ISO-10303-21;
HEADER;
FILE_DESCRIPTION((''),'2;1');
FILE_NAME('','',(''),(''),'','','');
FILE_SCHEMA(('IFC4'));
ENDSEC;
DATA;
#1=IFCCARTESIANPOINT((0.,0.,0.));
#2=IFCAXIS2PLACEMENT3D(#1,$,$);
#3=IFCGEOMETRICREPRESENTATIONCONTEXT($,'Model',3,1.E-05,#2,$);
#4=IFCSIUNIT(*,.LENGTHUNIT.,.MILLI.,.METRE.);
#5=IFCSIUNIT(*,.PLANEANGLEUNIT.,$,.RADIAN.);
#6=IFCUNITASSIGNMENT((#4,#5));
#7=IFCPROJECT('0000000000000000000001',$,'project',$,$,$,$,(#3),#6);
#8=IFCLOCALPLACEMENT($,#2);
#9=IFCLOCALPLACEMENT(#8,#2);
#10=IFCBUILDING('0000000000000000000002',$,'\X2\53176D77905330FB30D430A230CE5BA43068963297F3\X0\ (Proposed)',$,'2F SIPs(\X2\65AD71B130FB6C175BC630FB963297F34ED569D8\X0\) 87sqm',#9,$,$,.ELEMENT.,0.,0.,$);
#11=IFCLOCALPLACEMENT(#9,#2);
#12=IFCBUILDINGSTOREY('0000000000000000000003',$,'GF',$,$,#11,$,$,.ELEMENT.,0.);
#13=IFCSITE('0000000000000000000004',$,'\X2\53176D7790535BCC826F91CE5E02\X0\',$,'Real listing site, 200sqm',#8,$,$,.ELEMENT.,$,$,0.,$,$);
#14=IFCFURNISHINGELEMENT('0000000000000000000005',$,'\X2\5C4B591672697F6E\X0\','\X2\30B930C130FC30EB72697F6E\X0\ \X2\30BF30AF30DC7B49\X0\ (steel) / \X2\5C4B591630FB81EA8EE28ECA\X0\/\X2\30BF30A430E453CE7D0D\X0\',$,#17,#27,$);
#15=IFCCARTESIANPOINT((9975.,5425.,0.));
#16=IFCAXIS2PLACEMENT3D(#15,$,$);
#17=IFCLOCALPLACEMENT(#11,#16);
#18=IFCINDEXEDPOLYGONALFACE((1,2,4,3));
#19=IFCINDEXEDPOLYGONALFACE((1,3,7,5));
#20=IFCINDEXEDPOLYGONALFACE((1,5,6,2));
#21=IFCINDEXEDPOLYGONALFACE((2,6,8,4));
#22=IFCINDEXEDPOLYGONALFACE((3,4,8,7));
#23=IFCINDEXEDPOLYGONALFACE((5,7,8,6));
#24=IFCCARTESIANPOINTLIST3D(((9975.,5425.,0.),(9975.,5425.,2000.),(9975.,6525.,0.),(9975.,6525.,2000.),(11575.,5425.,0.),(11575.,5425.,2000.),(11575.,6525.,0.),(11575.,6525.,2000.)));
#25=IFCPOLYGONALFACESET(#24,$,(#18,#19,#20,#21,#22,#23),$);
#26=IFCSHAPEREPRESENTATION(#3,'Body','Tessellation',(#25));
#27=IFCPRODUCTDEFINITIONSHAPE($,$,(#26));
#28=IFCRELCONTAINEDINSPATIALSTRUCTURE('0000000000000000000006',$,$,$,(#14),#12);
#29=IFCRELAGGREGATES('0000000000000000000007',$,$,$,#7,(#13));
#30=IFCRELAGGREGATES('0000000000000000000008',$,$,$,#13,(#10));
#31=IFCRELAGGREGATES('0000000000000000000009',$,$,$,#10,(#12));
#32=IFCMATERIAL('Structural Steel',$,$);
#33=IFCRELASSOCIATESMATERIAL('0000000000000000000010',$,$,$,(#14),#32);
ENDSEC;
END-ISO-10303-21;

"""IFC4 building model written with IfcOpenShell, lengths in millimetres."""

from ifc_helpers import new_model, si_unit, frame, frame_2d, origin, place, context, project, spatial, rectangle, extrude, material, element, save


model = new_model("IFC4")

# Units and contexts
model_context = context("Model", 3, precision=1e-05, world=origin())
ifc_project = project(units=[si_unit("LENGTHUNIT", "METRE", prefix="MILLI"), si_unit("PLANEANGLEUNIT", "RADIAN")], contexts=[model_context])

# Site, building, storey
site_placement = place(None, origin())
site = spatial("IfcSite", under=ifc_project, at=site_placement, Name="北海道富良野市", ObjectType="Real listing site, 200sqm", CompositionType="ELEMENT", RefElevation=0.0)
building_placement = place(site_placement, origin())
building = spatial("IfcBuilding", under=site, at=building_placement, Name="北海道・ピアノ室と防音 (Proposed)", ObjectType="2F SIPs(断熱・気密・防音仕様) 87sqm", CompositionType="ELEMENT", ElevationOfRefHeight=0.0, ElevationOfTerrain=0.0)
storey_placement = place(building_placement, origin())
storey = spatial("IfcBuildingStorey", under=building, at=storey_placement, Name="GF", CompositionType="ELEMENT", Elevation=0.0)

# Shared definitions
ifc_material_1 = material(Name="Structural Steel")

# Furnishing element
furnishing_1_placement = place(storey_placement, frame((9975.0, 5425.0, 0.0)))
element("IfcFurnishingElement", 1, at=furnishing_1_placement, inside=storey, material=ifc_material_1, Name="屋外物置", Description="スチール物置 タクボ等 (steel) / 屋外・自転車/タイヤ収納", context=model_context, shape_type="SweptSolid", body=[
    extrude(rectangle(XDim=1600.0, YDim=1100.0, at=frame_2d((800.0, 550.0))), frame((9975.0, 5425.0, 0.0)), (0.0, 0.0, 1.0), 2000.0),
])

save(model, "model.ifc")
